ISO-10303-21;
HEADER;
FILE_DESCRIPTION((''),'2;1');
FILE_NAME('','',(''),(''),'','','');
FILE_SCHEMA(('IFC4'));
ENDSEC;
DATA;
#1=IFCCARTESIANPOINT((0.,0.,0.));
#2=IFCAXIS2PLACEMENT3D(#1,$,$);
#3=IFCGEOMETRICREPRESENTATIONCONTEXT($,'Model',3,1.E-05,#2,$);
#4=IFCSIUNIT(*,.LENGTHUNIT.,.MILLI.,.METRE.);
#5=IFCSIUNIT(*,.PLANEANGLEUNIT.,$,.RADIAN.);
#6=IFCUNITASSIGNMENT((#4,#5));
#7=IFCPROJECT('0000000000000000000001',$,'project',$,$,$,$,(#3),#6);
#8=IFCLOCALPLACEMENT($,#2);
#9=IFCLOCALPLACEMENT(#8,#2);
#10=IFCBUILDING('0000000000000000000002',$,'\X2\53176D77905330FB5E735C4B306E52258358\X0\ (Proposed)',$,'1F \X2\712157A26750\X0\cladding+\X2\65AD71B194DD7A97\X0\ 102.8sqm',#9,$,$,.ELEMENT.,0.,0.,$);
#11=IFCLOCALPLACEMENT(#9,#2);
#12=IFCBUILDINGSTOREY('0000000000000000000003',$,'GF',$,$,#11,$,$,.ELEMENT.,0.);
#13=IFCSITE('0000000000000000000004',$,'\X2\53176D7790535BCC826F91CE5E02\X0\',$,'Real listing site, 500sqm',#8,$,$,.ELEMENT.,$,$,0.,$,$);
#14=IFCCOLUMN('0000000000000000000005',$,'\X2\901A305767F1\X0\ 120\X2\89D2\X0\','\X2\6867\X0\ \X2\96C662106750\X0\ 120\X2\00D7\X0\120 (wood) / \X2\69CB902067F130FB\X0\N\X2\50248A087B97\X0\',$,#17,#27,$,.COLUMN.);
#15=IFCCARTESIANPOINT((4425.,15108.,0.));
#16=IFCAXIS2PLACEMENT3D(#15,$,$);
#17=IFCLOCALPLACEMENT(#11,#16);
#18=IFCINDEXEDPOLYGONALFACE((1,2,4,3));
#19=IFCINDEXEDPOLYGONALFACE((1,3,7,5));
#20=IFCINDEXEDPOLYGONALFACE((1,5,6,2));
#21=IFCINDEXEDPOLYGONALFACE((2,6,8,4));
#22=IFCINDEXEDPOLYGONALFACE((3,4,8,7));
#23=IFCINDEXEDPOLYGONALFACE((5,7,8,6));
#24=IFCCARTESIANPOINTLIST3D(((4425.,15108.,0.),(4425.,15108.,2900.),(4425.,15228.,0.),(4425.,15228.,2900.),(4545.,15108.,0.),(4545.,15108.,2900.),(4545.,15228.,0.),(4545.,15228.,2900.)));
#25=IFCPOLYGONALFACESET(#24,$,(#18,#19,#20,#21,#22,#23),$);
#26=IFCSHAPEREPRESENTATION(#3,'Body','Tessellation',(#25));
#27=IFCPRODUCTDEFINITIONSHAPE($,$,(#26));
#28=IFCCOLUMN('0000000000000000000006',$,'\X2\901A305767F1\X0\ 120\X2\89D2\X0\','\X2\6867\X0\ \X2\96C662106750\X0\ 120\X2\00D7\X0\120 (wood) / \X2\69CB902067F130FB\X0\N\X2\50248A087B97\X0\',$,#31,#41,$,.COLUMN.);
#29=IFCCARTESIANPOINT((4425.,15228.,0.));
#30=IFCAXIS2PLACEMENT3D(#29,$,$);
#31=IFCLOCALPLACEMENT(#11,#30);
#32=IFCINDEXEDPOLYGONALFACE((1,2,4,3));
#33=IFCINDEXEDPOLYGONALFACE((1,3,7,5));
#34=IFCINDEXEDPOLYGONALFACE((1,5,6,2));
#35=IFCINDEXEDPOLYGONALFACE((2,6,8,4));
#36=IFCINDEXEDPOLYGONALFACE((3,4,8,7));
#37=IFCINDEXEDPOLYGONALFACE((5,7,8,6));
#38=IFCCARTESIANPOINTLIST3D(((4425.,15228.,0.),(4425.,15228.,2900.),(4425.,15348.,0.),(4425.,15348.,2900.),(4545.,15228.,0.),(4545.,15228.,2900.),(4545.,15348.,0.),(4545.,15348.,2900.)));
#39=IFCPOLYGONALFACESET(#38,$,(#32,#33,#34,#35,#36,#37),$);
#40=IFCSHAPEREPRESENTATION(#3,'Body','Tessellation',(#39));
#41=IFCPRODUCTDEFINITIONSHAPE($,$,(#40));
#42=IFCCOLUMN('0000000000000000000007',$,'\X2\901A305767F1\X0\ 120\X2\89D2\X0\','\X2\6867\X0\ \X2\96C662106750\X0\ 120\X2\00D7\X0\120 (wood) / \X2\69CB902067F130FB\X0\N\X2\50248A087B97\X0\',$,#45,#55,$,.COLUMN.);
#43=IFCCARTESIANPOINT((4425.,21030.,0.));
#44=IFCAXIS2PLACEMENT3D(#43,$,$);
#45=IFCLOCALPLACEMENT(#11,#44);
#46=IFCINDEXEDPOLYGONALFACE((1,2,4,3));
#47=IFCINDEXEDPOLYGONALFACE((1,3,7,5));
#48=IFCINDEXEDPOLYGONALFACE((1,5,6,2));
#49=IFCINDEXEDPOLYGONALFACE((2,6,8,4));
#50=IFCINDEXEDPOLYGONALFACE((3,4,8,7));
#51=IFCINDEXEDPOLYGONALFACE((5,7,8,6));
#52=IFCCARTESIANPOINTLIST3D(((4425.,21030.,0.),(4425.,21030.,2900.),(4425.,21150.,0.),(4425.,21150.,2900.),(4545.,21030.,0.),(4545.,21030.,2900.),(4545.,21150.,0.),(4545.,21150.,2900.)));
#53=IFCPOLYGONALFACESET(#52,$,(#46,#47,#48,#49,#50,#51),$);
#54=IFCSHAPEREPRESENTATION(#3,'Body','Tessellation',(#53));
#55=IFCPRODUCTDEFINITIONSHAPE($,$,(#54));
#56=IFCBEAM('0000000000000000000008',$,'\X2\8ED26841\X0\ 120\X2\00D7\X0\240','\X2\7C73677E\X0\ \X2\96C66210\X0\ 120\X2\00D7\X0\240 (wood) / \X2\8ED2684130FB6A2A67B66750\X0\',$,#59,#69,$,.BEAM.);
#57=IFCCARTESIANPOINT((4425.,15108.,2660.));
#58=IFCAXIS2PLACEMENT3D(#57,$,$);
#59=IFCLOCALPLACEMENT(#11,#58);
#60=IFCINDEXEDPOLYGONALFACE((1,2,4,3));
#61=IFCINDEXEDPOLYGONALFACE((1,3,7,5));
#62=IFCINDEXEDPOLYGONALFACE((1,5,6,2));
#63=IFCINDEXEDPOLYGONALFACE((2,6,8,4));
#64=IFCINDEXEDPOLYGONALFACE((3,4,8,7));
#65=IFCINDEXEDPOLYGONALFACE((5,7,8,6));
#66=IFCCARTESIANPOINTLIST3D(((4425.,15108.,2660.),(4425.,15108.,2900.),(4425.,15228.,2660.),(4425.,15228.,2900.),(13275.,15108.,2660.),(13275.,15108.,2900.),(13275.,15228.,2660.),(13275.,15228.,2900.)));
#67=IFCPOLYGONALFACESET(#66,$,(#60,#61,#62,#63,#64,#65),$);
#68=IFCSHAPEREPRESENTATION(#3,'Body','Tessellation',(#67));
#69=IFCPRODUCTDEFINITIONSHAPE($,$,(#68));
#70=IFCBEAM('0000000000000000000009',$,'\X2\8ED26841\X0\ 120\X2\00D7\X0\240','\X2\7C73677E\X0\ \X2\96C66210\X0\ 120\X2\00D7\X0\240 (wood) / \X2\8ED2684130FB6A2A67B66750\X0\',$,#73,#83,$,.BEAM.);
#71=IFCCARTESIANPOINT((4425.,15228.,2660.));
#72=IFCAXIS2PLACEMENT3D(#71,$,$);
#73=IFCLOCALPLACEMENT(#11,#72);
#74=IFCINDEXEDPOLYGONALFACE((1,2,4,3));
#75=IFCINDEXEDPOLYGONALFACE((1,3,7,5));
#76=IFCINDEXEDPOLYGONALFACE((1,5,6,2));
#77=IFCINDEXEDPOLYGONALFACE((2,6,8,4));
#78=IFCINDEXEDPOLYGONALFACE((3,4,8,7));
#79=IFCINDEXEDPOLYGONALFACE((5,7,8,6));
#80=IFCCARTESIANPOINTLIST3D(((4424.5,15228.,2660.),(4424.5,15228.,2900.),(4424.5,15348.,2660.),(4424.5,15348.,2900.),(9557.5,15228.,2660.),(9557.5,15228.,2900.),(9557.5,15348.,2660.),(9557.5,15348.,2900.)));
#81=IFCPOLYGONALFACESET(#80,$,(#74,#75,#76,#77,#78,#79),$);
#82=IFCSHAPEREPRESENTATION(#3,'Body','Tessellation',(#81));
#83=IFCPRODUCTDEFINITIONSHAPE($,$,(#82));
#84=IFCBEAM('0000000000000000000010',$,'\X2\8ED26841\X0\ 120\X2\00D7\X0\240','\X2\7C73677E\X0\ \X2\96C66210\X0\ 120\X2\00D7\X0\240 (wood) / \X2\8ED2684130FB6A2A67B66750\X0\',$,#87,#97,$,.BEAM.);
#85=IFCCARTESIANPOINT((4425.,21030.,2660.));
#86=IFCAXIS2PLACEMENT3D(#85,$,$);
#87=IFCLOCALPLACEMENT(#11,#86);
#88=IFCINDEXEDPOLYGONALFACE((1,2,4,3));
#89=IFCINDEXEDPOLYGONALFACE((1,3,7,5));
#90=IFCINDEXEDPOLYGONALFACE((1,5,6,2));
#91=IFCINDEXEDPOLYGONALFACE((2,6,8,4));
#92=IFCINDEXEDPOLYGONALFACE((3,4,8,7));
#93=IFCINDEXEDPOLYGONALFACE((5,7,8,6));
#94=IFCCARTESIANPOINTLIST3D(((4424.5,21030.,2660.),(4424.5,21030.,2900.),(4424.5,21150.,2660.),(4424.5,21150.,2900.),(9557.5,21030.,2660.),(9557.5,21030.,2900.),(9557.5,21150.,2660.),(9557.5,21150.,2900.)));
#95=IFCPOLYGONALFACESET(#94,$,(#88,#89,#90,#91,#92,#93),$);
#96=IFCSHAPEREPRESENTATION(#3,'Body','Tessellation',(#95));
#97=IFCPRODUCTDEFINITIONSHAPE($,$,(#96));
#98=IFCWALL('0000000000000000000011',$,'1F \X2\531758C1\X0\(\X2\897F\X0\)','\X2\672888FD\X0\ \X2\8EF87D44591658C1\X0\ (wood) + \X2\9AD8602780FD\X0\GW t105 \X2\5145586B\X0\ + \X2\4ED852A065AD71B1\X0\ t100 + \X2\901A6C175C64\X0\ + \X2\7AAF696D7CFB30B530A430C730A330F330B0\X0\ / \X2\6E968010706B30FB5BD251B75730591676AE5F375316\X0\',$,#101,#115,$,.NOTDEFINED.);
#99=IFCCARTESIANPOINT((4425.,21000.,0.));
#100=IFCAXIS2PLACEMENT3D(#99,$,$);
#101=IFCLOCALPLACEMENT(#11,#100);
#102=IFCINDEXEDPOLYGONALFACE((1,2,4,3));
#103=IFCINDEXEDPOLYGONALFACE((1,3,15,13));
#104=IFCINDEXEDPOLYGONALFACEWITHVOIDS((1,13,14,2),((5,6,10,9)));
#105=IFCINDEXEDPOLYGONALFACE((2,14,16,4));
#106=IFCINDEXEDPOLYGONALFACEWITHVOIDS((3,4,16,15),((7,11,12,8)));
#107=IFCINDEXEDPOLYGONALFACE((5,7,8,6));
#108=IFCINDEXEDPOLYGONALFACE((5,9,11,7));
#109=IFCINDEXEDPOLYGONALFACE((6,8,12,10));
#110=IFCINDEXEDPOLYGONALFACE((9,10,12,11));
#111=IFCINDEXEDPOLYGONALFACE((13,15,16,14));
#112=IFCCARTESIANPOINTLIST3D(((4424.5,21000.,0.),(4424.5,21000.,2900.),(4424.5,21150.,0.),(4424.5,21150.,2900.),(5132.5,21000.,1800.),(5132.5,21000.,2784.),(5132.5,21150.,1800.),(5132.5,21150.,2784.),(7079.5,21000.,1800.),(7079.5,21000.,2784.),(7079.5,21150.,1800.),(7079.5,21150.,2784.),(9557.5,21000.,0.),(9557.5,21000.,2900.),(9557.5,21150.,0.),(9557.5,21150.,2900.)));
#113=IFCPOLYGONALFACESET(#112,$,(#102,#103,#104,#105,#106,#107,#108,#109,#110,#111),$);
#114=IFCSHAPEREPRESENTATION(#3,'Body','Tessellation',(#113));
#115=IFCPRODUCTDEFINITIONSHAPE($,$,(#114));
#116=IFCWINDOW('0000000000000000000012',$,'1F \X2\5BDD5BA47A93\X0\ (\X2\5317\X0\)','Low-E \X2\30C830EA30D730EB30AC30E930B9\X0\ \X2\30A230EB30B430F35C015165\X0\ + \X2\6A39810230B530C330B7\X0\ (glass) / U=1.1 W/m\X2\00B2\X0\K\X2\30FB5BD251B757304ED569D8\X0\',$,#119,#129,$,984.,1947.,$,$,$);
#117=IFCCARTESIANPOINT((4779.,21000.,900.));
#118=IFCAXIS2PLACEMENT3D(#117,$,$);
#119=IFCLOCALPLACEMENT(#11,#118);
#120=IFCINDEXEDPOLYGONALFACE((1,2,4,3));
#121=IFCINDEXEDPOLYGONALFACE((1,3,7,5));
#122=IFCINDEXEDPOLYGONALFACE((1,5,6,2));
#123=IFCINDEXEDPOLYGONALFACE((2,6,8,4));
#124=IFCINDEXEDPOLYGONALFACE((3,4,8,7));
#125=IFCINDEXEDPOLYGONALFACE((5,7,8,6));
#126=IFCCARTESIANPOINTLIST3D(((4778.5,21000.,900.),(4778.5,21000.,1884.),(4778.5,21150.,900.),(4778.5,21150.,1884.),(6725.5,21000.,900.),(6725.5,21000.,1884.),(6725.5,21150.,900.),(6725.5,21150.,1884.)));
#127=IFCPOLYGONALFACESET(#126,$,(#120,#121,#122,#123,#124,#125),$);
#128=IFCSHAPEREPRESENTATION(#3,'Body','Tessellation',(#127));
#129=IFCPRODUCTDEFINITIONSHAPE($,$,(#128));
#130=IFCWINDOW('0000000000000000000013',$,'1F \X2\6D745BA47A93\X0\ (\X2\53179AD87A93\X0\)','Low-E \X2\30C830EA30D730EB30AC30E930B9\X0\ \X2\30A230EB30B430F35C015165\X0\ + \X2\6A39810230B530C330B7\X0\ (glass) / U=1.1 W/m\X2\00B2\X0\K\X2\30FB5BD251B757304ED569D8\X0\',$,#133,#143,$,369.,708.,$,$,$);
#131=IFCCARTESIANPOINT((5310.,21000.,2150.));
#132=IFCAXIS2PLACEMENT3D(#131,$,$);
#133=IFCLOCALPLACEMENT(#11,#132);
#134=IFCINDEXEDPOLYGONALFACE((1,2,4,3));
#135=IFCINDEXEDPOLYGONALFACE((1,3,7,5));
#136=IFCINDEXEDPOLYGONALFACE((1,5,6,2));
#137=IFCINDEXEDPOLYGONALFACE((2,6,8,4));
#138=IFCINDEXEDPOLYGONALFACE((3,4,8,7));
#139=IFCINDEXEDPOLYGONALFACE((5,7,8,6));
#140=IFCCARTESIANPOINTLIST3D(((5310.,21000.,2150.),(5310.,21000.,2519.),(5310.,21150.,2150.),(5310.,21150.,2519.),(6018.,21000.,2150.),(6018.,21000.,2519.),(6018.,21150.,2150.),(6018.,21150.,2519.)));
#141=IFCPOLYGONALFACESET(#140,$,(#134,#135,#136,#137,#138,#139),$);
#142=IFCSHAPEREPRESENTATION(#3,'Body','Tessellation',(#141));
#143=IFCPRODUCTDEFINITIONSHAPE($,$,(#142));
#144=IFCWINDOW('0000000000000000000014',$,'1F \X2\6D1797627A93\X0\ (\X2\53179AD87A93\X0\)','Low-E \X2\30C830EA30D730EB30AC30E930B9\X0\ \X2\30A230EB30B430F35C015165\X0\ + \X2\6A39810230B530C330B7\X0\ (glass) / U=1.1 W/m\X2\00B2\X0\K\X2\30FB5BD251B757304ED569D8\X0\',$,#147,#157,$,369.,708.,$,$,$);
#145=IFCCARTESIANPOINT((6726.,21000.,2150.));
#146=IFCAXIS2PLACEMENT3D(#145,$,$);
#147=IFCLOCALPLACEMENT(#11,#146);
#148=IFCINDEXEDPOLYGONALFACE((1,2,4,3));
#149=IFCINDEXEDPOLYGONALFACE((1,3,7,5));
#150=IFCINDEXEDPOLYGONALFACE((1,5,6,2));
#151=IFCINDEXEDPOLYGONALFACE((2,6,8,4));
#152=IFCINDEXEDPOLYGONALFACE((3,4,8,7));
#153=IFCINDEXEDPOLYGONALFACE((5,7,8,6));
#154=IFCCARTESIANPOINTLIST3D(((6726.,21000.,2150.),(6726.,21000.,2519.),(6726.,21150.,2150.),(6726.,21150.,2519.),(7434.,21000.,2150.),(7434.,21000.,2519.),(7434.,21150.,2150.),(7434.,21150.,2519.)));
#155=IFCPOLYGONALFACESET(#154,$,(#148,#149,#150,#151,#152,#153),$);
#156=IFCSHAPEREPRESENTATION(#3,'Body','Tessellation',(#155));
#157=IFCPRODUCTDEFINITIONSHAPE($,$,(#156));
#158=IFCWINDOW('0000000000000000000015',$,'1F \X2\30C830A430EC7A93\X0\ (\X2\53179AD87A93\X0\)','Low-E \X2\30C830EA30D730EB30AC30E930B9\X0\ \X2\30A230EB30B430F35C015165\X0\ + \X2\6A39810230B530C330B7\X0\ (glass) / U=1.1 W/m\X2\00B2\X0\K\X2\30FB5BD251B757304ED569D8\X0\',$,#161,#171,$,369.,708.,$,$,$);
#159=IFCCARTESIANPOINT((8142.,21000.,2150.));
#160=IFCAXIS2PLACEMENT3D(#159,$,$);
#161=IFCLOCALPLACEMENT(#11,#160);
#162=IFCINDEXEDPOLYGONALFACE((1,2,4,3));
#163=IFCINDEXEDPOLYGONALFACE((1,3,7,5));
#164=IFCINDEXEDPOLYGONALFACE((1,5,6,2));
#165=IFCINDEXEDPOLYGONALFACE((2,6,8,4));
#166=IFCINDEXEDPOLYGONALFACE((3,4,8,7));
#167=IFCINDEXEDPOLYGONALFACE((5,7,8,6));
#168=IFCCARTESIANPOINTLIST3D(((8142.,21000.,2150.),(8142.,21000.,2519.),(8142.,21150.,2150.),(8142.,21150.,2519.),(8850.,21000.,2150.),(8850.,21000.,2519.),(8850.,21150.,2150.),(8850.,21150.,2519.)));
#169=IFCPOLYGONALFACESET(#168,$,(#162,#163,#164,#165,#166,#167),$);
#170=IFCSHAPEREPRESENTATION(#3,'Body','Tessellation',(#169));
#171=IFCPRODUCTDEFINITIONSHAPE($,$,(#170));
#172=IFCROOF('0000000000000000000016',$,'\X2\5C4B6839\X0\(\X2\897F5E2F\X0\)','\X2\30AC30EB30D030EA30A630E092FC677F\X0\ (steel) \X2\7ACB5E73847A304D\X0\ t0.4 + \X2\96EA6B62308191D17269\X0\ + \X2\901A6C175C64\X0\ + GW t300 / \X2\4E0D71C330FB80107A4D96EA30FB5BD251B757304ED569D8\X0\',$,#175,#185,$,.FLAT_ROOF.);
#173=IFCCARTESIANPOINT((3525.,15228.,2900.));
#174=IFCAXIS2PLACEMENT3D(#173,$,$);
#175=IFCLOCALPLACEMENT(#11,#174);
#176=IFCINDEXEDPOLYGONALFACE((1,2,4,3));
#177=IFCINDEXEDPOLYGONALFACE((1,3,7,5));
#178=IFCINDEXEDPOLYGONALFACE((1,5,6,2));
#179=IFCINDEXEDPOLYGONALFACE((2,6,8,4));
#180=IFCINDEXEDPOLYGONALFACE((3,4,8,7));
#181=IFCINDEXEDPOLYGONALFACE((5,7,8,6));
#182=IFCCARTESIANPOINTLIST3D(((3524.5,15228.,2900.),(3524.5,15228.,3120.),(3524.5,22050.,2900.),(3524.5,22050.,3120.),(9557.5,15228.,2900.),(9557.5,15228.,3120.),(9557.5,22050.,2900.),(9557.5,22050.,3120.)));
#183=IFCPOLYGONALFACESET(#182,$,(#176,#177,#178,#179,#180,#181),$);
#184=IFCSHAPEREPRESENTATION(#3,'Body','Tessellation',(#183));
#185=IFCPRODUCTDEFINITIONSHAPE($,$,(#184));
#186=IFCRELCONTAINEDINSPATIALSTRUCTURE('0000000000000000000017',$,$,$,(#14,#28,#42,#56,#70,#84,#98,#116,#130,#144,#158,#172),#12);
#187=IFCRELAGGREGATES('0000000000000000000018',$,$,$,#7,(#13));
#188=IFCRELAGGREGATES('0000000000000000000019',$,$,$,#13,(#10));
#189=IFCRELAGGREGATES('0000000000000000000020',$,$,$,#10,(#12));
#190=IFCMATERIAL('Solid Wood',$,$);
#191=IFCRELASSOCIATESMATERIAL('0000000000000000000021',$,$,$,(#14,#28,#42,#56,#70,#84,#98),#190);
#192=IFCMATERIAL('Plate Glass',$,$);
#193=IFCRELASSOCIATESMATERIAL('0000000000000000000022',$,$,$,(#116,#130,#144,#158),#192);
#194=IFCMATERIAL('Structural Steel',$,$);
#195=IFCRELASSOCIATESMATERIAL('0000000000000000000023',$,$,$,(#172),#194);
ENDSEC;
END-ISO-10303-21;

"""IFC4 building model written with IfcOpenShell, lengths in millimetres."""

from ifc_helpers import new_model, si_unit, frame, frame_2d, origin, place, context, project, spatial, rectangle, extrude, material, element, fill, save


model = new_model("IFC4")

# Units and contexts
model_context = context("Model", 3, precision=1e-05, world=origin())
ifc_project = project(units=[si_unit("LENGTHUNIT", "METRE", prefix="MILLI"), si_unit("PLANEANGLEUNIT", "RADIAN")], contexts=[model_context])

# Site, building, storey
site_placement = place(None, origin())
site = spatial("IfcSite", under=ifc_project, at=site_placement, Name="北海道富良野市", ObjectType="Real listing site, 500sqm", CompositionType="ELEMENT", RefElevation=0.0)
building_placement = place(site_placement, origin())
building = spatial("IfcBuilding", under=site, at=building_placement, Name="北海道・平屋の別荘 (Proposed)", ObjectType="1F 無垢材cladding+断熱铝窗 102.8sqm", CompositionType="ELEMENT", ElevationOfRefHeight=0.0, ElevationOfTerrain=0.0)
storey_placement = place(building_placement, origin())
storey = spatial("IfcBuildingStorey", under=building, at=storey_placement, Name="GF", CompositionType="ELEMENT", Elevation=0.0)

# Columns
ifc_material_1 = material(Name="Solid Wood")
column_1_placement = place(storey_placement, frame((4425.0, 15108.0, 0.0)))
element("IfcColumn", 1, at=column_1_placement, inside=storey, material=ifc_material_1, Name="通し柱 120角", Description="桧 集成材 120×120 (wood) / 構造柱・N値計算", PredefinedType="COLUMN", context=model_context, shape_type="SweptSolid", body=[
    extrude(rectangle(XDim=120.0, YDim=120.0, at=frame_2d((60.0, 60.0))), frame((4425.0, 15108.0, 0.0)), (0.0, 0.0, 1.0), 2900.0),
])
column_2_placement = place(storey_placement, frame((4425.0, 15228.0, 0.0)))
element("IfcColumn", 2, at=column_2_placement, inside=storey, material=ifc_material_1, Name="通し柱 120角", Description="桧 集成材 120×120 (wood) / 構造柱・N値計算", PredefinedType="COLUMN", context=model_context, shape_type="SweptSolid", body=[
    extrude(rectangle(XDim=120.0, YDim=120.0, at=frame_2d((60.0, 60.0))), frame((4425.0, 15228.0, 0.0)), (0.0, 0.0, 1.0), 2900.0),
])
column_3_placement = place(storey_placement, frame((4425.0, 21030.0, 0.0)))
element("IfcColumn", 3, at=column_3_placement, inside=storey, material=ifc_material_1, Name="通し柱 120角", Description="桧 集成材 120×120 (wood) / 構造柱・N値計算", PredefinedType="COLUMN", context=model_context, shape_type="SweptSolid", body=[
    extrude(rectangle(XDim=120.0, YDim=120.0, at=frame_2d((60.0, 60.0))), frame((4425.0, 21030.0, 0.0)), (0.0, 0.0, 1.0), 2900.0),
])

# Beams
beam_1_placement = place(storey_placement, frame((4425.0, 15108.0, 2660.0)))
element("IfcBeam", 4, at=beam_1_placement, inside=storey, material=ifc_material_1, Name="軒桁 120×240", Description="米松 集成 120×240 (wood) / 軒桁・横架材", PredefinedType="BEAM", context=model_context, shape_type="SweptSolid", body=[
    extrude(rectangle(XDim=8850.0, YDim=120.0, at=frame_2d((4425.0, 60.0))), frame((4425.0, 15108.0, 2660.0)), (0.0, 0.0, 1.0), 240.0),
])
beam_2_placement = place(storey_placement, frame((4425.0, 15228.0, 2660.0)))
element("IfcBeam", 5, at=beam_2_placement, inside=storey, material=ifc_material_1, Name="軒桁 120×240", Description="米松 集成 120×240 (wood) / 軒桁・横架材", PredefinedType="BEAM", context=model_context, shape_type="SweptSolid", body=[
    extrude(rectangle(XDim=5133.0, YDim=120.0, at=frame_2d((2566.0, 60.0))), frame((4425.0, 15228.0, 2660.0)), (0.0, 0.0, 1.0), 240.0),
])
beam_3_placement = place(storey_placement, frame((4425.0, 21030.0, 2660.0)))
element("IfcBeam", 6, at=beam_3_placement, inside=storey, material=ifc_material_1, Name="軒桁 120×240", Description="米松 集成 120×240 (wood) / 軒桁・横架材", PredefinedType="BEAM", context=model_context, shape_type="SweptSolid", body=[
    extrude(rectangle(XDim=5133.0, YDim=120.0, at=frame_2d((2566.0, 60.0))), frame((4425.0, 21030.0, 2660.0)), (0.0, 0.0, 1.0), 240.0),
])

# Wall, openings, windows
wall_1_placement = place(storey_placement, frame((4425.0, 21000.0, 0.0)))
wall_1 = element("IfcWall", 7, at=wall_1_placement, inside=storey, material=ifc_material_1, Name="1F 北壁(西)", Description="木製 軸組外壁 (wood) + 高性能GW t105 充填 + 付加断熱 t100 + 通気層 + 窯業系サイディング / 準耐火・寒冷地外皮強化", PredefinedType="NOTDEFINED", context=model_context, shape_type="SweptSolid", body=[
    extrude(rectangle(XDim=5133.0, YDim=150.0, at=frame_2d((2566.0, 75.0))), frame((4425.0, 21000.0, 0.0)), (0.0, 0.0, 1.0), 2900.0),
])
opening_1_placement = place(storey_placement, frame((4779.0, 21000.0, 900.0)))
opening_1 = element("IfcOpeningElement", 8, at=opening_1_placement, cuts=wall_1, PredefinedType="NOTDEFINED", context=model_context, shape_type="SweptSolid", body=[
    extrude(rectangle(XDim=1947.0, YDim=150.0, at=frame_2d((973.0, 75.0))), frame((4779.0, 21000.0, 900.0)), (0.0, 0.0, 1.0), 984.0),
])
opening_2_placement = place(storey_placement, frame((5310.0, 21000.0, 2150.0)))
opening_2 = element("IfcOpeningElement", 9, at=opening_2_placement, cuts=wall_1, PredefinedType="NOTDEFINED", context=model_context, shape_type="SweptSolid", body=[
    extrude(rectangle(XDim=708.0, YDim=150.0, at=frame_2d((354.0, 75.0))), frame((5310.0, 21000.0, 2150.0)), (0.0, 0.0, 1.0), 369.0),
])
opening_3_placement = place(storey_placement, frame((6726.0, 21000.0, 2150.0)))
opening_3 = element("IfcOpeningElement", 10, at=opening_3_placement, cuts=wall_1, PredefinedType="NOTDEFINED", context=model_context, shape_type="SweptSolid", body=[
    extrude(rectangle(XDim=708.0, YDim=150.0, at=frame_2d((354.0, 75.0))), frame((6726.0, 21000.0, 2150.0)), (0.0, 0.0, 1.0), 369.0),
])
opening_4_placement = place(storey_placement, frame((8142.0, 21000.0, 2150.0)))
opening_4 = element("IfcOpeningElement", 11, at=opening_4_placement, cuts=wall_1, PredefinedType="NOTDEFINED", context=model_context, shape_type="SweptSolid", body=[
    extrude(rectangle(XDim=708.0, YDim=150.0, at=frame_2d((354.0, 75.0))), frame((8142.0, 21000.0, 2150.0)), (0.0, 0.0, 1.0), 369.0),
])
ifc_material_2 = material(Name="Plate Glass")
window_1_placement = place(storey_placement, frame((4779.0, 21000.0, 900.0)))
window_1 = element("IfcWindow", 12, at=window_1_placement, inside=storey, material=ifc_material_2, Name="1F 寝室窓 (北)", Description="Low-E トリプルガラス アルゴン封入 + 樹脂サッシ (glass) / U=1.1 W/m²K・寒冷地仕様", OverallHeight=984.0, OverallWidth=1947.0, context=model_context, shape_type="SweptSolid", body=[
    extrude(rectangle(XDim=1947.0, YDim=150.0, at=frame_2d((973.0, 75.0))), frame((4779.0, 21000.0, 900.0)), (0.0, 0.0, 1.0), 984.0),
])
fill(opening_1, window_1)
window_2_placement = place(storey_placement, frame((5310.0, 21000.0, 2150.0)))
window_2 = element("IfcWindow", 13, at=window_2_placement, inside=storey, material=ifc_material_2, Name="1F 浴室窓 (北高窓)", Description="Low-E トリプルガラス アルゴン封入 + 樹脂サッシ (glass) / U=1.1 W/m²K・寒冷地仕様", OverallHeight=369.0, OverallWidth=708.0, context=model_context, shape_type="SweptSolid", body=[
    extrude(rectangle(XDim=708.0, YDim=150.0, at=frame_2d((354.0, 75.0))), frame((5310.0, 21000.0, 2150.0)), (0.0, 0.0, 1.0), 369.0),
])
fill(opening_2, window_2)
window_3_placement = place(storey_placement, frame((6726.0, 21000.0, 2150.0)))
window_3 = element("IfcWindow", 14, at=window_3_placement, inside=storey, material=ifc_material_2, Name="1F 洗面窓 (北高窓)", Description="Low-E トリプルガラス アルゴン封入 + 樹脂サッシ (glass) / U=1.1 W/m²K・寒冷地仕様", OverallHeight=369.0, OverallWidth=708.0, context=model_context, shape_type="SweptSolid", body=[
    extrude(rectangle(XDim=708.0, YDim=150.0, at=frame_2d((354.0, 75.0))), frame((6726.0, 21000.0, 2150.0)), (0.0, 0.0, 1.0), 369.0),
])
fill(opening_3, window_3)
window_4_placement = place(storey_placement, frame((8142.0, 21000.0, 2150.0)))
window_4 = element("IfcWindow", 15, at=window_4_placement, inside=storey, material=ifc_material_2, Name="1F トイレ窓 (北高窓)", Description="Low-E トリプルガラス アルゴン封入 + 樹脂サッシ (glass) / U=1.1 W/m²K・寒冷地仕様", OverallHeight=369.0, OverallWidth=708.0, context=model_context, shape_type="SweptSolid", body=[
    extrude(rectangle(XDim=708.0, YDim=150.0, at=frame_2d((354.0, 75.0))), frame((8142.0, 21000.0, 2150.0)), (0.0, 0.0, 1.0), 369.0),
])
fill(opening_4, window_4)

# Roof
ifc_material_3 = material(Name="Structural Steel")
roof_placement = place(storey_placement, frame((3525.0, 15228.0, 2900.0)))
element("IfcRoof", 16, at=roof_placement, inside=storey, material=ifc_material_3, Name="屋根(西帯)", Description="ガルバリウム鋼板 (steel) 立平葺き t0.4 + 雪止め金物 + 通気層 + GW t300 / 不燃・耐積雪・寒冷地仕様", PredefinedType="FLAT_ROOF", context=model_context, shape_type="SweptSolid", body=[
    extrude(rectangle(XDim=6033.0, YDim=6822.0, at=frame_2d((3016.0, 3411.0))), frame((3525.0, 15228.0, 2900.0)), (0.0, 0.0, 1.0), 220.0),
])

save(model, "model.ifc")
